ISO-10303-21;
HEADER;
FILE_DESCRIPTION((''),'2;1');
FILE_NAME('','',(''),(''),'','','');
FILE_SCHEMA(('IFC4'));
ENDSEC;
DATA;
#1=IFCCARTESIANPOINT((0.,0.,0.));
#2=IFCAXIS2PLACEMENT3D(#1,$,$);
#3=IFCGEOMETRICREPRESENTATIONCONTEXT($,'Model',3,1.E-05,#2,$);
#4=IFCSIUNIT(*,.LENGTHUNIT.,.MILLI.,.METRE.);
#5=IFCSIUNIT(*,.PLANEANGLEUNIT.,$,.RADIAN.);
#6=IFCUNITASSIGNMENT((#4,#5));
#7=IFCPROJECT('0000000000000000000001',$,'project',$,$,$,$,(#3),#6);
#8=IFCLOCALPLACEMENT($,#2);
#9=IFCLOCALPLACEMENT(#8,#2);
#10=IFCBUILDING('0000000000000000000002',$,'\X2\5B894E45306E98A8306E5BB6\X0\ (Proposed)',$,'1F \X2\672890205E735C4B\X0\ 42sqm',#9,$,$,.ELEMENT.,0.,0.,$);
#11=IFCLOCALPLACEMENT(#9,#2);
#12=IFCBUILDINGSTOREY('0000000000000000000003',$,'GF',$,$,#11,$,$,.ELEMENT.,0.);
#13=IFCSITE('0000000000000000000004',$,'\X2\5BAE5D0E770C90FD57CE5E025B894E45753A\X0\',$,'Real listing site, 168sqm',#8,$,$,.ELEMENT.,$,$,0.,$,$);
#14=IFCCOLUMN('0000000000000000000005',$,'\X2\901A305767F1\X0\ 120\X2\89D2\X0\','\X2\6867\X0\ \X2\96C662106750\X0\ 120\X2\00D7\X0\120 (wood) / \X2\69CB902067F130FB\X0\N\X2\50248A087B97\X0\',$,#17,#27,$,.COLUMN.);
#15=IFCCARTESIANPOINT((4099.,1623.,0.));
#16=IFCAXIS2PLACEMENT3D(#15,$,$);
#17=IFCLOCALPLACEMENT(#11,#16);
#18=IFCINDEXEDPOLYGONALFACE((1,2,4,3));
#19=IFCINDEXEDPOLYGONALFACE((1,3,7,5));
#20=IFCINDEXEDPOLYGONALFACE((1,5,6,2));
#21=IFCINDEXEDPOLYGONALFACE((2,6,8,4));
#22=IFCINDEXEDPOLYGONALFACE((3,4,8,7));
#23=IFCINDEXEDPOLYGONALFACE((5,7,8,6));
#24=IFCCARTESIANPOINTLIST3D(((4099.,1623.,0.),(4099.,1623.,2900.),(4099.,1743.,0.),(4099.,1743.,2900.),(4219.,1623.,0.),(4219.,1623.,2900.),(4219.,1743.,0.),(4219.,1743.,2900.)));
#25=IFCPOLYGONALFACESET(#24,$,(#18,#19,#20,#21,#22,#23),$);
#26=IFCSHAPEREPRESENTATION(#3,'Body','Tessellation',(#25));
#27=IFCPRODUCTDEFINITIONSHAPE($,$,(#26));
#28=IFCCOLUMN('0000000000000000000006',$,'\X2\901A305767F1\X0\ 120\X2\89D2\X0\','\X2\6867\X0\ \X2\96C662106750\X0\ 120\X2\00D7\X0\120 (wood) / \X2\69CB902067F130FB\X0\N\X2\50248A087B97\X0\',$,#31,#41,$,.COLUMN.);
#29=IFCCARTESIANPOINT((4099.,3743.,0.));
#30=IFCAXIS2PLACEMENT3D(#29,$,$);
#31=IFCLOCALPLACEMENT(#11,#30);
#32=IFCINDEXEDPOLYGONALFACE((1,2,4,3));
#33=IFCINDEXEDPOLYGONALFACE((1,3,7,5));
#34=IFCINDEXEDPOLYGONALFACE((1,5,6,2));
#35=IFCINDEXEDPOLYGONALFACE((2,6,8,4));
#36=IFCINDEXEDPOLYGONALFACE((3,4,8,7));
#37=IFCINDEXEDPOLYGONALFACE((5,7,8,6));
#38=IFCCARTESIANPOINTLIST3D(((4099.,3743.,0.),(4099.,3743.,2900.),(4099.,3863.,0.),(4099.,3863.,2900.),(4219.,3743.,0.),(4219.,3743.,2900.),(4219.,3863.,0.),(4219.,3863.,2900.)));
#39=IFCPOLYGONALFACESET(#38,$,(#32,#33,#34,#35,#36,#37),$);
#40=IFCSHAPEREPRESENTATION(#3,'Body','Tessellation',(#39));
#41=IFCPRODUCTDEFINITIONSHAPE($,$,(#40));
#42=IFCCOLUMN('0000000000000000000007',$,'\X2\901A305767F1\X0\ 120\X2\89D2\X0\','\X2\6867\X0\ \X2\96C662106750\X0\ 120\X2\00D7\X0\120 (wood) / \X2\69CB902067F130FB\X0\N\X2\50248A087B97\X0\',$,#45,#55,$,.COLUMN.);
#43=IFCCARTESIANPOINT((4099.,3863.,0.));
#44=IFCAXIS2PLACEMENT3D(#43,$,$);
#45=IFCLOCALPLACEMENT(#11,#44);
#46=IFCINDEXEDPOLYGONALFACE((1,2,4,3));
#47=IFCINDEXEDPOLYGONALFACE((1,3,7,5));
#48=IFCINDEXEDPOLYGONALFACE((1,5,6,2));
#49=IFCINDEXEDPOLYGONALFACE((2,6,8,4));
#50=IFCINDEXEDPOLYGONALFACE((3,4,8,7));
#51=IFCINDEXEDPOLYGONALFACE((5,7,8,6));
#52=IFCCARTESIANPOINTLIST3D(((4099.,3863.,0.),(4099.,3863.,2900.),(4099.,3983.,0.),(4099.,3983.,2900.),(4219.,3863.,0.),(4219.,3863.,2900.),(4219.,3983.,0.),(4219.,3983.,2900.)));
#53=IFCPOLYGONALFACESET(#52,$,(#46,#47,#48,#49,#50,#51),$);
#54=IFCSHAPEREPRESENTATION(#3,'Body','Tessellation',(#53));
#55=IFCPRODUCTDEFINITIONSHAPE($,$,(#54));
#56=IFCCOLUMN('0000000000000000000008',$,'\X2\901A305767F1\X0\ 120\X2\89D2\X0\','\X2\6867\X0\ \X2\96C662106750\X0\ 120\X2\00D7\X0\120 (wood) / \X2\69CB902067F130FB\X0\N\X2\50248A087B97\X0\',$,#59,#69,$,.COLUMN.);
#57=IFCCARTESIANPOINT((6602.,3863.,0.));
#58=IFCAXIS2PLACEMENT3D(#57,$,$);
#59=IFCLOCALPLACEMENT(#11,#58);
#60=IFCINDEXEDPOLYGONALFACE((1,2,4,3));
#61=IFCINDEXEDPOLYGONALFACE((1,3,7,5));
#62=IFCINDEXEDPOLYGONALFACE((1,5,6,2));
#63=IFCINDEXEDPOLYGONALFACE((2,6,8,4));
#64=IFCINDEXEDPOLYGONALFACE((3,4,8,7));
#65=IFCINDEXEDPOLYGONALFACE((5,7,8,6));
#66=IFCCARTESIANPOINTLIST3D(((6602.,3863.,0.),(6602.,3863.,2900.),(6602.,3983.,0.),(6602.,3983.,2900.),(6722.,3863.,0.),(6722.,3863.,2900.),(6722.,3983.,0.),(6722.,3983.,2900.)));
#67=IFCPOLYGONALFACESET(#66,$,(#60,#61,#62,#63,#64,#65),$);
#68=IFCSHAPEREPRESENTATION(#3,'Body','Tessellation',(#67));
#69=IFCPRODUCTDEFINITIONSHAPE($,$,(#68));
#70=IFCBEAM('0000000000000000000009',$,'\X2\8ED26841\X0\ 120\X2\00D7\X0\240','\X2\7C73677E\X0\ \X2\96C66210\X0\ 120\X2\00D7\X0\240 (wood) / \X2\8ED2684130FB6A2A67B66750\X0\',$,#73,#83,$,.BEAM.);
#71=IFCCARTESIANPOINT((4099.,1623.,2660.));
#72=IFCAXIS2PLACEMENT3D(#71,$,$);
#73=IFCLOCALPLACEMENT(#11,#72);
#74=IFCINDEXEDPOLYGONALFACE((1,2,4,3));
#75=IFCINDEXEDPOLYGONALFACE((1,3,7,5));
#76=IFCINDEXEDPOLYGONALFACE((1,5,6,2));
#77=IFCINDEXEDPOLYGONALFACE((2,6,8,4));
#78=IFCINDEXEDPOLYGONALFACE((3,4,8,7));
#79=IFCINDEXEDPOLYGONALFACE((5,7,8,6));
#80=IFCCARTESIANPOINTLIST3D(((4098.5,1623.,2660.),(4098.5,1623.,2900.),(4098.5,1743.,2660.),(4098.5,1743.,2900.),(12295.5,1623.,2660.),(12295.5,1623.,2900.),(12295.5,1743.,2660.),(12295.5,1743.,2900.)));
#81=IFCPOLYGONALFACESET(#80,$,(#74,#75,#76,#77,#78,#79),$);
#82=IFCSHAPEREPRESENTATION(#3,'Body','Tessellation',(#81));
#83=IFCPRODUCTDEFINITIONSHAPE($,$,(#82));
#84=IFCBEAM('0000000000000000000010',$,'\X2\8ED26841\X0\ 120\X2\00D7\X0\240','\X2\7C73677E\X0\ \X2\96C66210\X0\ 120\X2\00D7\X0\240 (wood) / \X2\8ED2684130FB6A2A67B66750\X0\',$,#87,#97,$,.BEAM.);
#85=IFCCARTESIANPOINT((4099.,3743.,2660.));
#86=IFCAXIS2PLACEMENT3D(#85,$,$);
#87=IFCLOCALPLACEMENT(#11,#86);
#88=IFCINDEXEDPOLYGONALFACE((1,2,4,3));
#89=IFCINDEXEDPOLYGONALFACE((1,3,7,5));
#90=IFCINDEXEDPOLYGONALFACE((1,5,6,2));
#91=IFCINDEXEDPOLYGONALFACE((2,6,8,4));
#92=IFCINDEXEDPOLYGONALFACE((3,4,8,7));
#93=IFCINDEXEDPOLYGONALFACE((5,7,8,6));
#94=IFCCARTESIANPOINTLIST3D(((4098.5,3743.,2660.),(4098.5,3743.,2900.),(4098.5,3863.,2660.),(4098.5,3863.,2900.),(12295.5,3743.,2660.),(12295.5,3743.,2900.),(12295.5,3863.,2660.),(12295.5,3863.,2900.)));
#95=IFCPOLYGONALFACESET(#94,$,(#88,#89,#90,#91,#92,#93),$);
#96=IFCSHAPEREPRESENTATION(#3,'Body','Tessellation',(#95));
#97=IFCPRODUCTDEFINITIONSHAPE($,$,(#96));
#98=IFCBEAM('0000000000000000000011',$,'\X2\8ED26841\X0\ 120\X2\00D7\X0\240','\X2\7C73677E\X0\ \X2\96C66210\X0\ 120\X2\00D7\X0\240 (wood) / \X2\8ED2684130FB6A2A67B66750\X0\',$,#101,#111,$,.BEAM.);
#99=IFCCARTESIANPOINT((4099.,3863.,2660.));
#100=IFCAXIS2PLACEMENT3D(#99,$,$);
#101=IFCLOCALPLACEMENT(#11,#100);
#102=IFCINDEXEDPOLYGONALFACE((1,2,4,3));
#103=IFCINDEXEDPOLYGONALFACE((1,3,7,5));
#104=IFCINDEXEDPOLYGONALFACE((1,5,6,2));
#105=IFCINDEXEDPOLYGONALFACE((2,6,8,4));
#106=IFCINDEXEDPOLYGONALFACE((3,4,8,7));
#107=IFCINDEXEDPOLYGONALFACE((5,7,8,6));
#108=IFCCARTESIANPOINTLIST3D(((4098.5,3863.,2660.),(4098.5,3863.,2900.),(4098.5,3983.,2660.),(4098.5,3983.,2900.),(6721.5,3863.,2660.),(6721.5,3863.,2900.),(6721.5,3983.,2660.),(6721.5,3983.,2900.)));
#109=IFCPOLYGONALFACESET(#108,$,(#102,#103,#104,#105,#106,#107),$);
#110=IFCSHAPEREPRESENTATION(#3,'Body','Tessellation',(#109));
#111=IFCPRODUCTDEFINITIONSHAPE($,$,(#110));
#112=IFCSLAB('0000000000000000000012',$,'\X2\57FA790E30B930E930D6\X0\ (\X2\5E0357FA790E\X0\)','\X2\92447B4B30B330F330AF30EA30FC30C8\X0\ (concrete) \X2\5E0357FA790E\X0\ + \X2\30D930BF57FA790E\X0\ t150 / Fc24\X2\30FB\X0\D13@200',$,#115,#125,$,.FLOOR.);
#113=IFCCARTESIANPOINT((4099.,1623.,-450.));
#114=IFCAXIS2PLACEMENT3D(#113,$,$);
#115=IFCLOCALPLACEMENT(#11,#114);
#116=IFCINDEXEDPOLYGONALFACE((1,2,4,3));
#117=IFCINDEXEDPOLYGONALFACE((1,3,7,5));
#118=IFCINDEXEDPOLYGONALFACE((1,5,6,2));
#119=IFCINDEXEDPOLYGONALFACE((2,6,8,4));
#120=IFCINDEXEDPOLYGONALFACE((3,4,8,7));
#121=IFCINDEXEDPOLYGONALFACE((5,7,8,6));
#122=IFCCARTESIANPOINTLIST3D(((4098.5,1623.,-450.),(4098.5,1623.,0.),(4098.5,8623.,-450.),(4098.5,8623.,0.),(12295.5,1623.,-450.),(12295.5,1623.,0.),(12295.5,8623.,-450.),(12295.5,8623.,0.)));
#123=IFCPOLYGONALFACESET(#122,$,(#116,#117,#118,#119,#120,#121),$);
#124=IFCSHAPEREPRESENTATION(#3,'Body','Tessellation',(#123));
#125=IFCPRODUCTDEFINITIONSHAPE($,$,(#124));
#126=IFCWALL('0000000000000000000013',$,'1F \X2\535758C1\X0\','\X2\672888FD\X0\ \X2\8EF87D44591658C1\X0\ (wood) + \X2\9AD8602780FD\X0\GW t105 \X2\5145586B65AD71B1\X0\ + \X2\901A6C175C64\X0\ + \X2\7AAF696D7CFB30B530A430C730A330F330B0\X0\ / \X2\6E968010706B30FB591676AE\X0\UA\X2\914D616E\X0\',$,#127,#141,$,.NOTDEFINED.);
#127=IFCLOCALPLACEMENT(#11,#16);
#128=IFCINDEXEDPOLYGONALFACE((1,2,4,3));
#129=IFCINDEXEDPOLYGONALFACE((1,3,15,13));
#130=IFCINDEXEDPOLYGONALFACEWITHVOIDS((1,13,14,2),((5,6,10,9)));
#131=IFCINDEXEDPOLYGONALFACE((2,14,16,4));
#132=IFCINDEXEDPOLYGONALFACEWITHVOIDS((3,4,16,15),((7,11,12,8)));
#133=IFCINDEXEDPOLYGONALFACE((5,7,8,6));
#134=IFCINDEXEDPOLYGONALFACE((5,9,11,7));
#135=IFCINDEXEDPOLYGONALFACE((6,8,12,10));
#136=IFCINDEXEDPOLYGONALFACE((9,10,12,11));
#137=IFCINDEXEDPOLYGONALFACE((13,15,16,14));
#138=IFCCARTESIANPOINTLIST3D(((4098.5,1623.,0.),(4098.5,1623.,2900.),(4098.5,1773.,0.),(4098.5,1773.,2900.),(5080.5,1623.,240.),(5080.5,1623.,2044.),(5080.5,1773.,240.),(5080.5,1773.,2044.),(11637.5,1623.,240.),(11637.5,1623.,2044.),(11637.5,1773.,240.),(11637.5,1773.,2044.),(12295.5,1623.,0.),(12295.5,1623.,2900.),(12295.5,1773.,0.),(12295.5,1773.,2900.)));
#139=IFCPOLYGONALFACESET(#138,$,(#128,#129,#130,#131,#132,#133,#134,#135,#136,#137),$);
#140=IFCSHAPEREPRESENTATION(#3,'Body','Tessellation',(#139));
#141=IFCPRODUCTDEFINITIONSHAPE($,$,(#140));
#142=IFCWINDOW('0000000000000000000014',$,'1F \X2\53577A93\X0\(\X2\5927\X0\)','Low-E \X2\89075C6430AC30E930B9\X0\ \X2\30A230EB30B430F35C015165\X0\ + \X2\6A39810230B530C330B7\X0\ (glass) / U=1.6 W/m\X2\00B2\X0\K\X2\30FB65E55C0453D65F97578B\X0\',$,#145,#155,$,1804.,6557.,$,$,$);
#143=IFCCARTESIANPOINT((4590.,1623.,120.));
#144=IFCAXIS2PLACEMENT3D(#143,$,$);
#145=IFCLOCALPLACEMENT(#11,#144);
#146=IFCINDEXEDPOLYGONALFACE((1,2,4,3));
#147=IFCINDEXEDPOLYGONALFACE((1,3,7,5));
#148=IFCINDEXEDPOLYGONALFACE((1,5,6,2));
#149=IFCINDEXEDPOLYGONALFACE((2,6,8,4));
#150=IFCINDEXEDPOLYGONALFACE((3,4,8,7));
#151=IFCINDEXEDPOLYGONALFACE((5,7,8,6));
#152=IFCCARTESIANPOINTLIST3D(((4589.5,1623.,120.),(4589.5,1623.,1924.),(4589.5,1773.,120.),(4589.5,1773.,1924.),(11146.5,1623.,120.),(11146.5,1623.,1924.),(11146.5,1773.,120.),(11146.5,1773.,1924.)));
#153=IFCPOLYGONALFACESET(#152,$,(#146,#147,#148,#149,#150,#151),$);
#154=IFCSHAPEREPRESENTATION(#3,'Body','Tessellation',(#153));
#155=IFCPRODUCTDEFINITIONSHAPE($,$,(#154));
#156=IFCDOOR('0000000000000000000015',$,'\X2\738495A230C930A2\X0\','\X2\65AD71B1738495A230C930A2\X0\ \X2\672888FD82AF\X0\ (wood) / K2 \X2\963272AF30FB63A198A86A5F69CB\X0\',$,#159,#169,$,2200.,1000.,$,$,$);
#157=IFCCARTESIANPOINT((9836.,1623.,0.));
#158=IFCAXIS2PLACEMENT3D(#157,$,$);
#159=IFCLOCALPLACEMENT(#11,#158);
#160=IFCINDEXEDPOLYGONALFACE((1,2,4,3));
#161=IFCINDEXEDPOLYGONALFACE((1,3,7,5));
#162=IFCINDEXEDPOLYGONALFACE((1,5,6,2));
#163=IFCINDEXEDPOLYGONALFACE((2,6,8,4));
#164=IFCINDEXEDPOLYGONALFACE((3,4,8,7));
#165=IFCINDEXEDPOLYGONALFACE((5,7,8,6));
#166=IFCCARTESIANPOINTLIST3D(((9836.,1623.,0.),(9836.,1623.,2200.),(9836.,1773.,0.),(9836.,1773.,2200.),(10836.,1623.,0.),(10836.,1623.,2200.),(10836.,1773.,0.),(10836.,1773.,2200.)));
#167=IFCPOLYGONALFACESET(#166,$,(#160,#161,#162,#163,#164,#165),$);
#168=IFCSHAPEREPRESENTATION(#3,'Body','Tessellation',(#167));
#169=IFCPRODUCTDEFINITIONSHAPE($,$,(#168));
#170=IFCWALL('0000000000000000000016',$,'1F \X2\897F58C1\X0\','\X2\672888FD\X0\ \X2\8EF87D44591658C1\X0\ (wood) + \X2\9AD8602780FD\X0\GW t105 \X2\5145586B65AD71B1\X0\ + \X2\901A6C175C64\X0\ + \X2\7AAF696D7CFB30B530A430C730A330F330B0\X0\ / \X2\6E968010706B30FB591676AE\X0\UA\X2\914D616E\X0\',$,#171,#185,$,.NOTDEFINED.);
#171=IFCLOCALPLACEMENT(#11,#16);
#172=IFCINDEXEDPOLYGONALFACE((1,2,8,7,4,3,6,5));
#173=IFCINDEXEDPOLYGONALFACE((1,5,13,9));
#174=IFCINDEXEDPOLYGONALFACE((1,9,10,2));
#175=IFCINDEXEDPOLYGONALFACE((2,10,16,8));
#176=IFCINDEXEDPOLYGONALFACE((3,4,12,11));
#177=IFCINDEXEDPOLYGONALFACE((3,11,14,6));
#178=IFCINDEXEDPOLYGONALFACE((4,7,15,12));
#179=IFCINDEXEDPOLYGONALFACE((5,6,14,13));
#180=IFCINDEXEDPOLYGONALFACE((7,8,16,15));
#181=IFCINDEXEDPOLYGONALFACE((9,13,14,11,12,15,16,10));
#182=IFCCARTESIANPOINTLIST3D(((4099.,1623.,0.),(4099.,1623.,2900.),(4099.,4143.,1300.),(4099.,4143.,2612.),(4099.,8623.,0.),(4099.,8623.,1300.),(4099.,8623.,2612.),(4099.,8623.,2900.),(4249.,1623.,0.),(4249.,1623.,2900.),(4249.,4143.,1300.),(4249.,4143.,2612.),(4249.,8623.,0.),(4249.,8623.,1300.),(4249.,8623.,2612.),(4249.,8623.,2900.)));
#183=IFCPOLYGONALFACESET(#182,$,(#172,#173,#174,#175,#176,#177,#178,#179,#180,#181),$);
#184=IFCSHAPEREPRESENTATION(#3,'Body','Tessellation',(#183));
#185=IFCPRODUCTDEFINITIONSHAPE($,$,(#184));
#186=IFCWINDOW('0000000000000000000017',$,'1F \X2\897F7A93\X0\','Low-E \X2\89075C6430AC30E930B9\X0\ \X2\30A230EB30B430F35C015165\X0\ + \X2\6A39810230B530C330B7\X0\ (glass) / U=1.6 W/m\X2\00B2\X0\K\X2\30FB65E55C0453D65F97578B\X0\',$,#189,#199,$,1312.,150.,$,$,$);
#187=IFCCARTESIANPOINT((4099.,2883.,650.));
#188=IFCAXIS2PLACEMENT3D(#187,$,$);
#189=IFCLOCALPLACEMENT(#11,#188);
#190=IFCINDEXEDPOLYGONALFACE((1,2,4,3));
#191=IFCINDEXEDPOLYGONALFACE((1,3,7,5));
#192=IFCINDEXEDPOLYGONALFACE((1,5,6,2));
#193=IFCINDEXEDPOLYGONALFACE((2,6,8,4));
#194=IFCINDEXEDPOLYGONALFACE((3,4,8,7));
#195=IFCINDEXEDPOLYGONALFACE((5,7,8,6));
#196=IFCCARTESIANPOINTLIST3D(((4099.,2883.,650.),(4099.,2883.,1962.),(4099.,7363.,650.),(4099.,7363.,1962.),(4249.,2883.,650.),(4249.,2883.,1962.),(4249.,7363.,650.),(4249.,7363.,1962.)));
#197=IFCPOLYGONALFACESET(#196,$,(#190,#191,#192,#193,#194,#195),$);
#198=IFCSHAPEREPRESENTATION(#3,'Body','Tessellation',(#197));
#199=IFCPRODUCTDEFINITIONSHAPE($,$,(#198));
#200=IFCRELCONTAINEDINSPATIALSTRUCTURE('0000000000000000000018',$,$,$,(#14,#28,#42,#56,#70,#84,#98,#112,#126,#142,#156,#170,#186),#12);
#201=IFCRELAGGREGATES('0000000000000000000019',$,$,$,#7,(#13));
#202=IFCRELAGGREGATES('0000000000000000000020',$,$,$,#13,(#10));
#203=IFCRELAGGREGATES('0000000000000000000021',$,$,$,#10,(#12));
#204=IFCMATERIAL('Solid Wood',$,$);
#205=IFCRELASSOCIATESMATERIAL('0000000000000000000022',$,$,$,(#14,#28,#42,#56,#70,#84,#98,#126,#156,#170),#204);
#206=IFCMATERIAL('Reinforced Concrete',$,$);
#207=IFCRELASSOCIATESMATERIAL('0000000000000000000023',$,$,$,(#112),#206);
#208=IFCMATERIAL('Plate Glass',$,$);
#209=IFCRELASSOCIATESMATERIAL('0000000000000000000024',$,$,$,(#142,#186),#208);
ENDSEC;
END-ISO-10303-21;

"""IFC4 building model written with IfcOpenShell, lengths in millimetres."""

from ifc_helpers import new_model, si_unit, frame, frame_2d, origin, place, context, project, spatial, rectangle, extrude, material, element, fill, save


model = new_model("IFC4")

# Units and contexts
model_context = context("Model", 3, precision=1e-05, world=origin())
ifc_project = project(units=[si_unit("LENGTHUNIT", "METRE", prefix="MILLI"), si_unit("PLANEANGLEUNIT", "RADIAN")], contexts=[model_context])

# Site, building, storey
site_placement = place(None, origin())
site = spatial("IfcSite", under=ifc_project, at=site_placement, Name="宮崎県都城市安久町", ObjectType="Real listing site, 168sqm", CompositionType="ELEMENT", RefElevation=0.0)
building_placement = place(site_placement, origin())
building = spatial("IfcBuilding", under=site, at=building_placement, Name="安久の風の家 (Proposed)", ObjectType="1F 木造平屋 42sqm", CompositionType="ELEMENT", ElevationOfRefHeight=0.0, ElevationOfTerrain=0.0)
storey_placement = place(building_placement, origin())
storey = spatial("IfcBuildingStorey", under=building, at=storey_placement, Name="GF", CompositionType="ELEMENT", Elevation=0.0)

# Columns
ifc_material_1 = material(Name="Solid Wood")
column_1_placement = place(storey_placement, frame((4099.0, 1623.0, 0.0)))
element("IfcColumn", 1, at=column_1_placement, inside=storey, material=ifc_material_1, Name="通し柱 120角", Description="桧 集成材 120×120 (wood) / 構造柱・N値計算", PredefinedType="COLUMN", context=model_context, shape_type="SweptSolid", body=[
    extrude(rectangle(XDim=120.0, YDim=120.0, at=frame_2d((60.0, 60.0))), frame((4099.0, 1623.0, 0.0)), (0.0, 0.0, 1.0), 2900.0),
])
column_2_placement = place(storey_placement, frame((4099.0, 3743.0, 0.0)))
element("IfcColumn", 2, at=column_2_placement, inside=storey, material=ifc_material_1, Name="通し柱 120角", Description="桧 集成材 120×120 (wood) / 構造柱・N値計算", PredefinedType="COLUMN", context=model_context, shape_type="SweptSolid", body=[
    extrude(rectangle(XDim=120.0, YDim=120.0, at=frame_2d((60.0, 60.0))), frame((4099.0, 3743.0, 0.0)), (0.0, 0.0, 1.0), 2900.0),
])
column_3_placement = place(storey_placement, frame((4099.0, 3863.0, 0.0)))
element("IfcColumn", 3, at=column_3_placement, inside=storey, material=ifc_material_1, Name="通し柱 120角", Description="桧 集成材 120×120 (wood) / 構造柱・N値計算", PredefinedType="COLUMN", context=model_context, shape_type="SweptSolid", body=[
    extrude(rectangle(XDim=120.0, YDim=120.0, at=frame_2d((60.0, 60.0))), frame((4099.0, 3863.0, 0.0)), (0.0, 0.0, 1.0), 2900.0),
])
column_4_placement = place(storey_placement, frame((6602.0, 3863.0, 0.0)))
element("IfcColumn", 4, at=column_4_placement, inside=storey, material=ifc_material_1, Name="通し柱 120角", Description="桧 集成材 120×120 (wood) / 構造柱・N値計算", PredefinedType="COLUMN", context=model_context, shape_type="SweptSolid", body=[
    extrude(rectangle(XDim=120.0, YDim=120.0, at=frame_2d((60.0, 60.0))), frame((6602.0, 3863.0, 0.0)), (0.0, 0.0, 1.0), 2900.0),
])

# Beams
beam_1_placement = place(storey_placement, frame((4099.0, 1623.0, 2660.0)))
element("IfcBeam", 5, at=beam_1_placement, inside=storey, material=ifc_material_1, Name="軒桁 120×240", Description="米松 集成 120×240 (wood) / 軒桁・横架材", PredefinedType="BEAM", context=model_context, shape_type="SweptSolid", body=[
    extrude(rectangle(XDim=8197.0, YDim=120.0, at=frame_2d((4098.0, 60.0))), frame((4099.0, 1623.0, 2660.0)), (0.0, 0.0, 1.0), 240.0),
])
beam_2_placement = place(storey_placement, frame((4099.0, 3743.0, 2660.0)))
element("IfcBeam", 6, at=beam_2_placement, inside=storey, material=ifc_material_1, Name="軒桁 120×240", Description="米松 集成 120×240 (wood) / 軒桁・横架材", PredefinedType="BEAM", context=model_context, shape_type="SweptSolid", body=[
    extrude(rectangle(XDim=8197.0, YDim=120.0, at=frame_2d((4098.0, 60.0))), frame((4099.0, 3743.0, 2660.0)), (0.0, 0.0, 1.0), 240.0),
])
beam_3_placement = place(storey_placement, frame((4099.0, 3863.0, 2660.0)))
element("IfcBeam", 7, at=beam_3_placement, inside=storey, material=ifc_material_1, Name="軒桁 120×240", Description="米松 集成 120×240 (wood) / 軒桁・横架材", PredefinedType="BEAM", context=model_context, shape_type="SweptSolid", body=[
    extrude(rectangle(XDim=2623.0, YDim=120.0, at=frame_2d((1311.0, 60.0))), frame((4099.0, 3863.0, 2660.0)), (0.0, 0.0, 1.0), 240.0),
])

# Slab
ifc_material_2 = material(Name="Reinforced Concrete")
slab_1_placement = place(storey_placement, frame((4099.0, 1623.0, -450.0)))
element("IfcSlab", 8, at=slab_1_placement, inside=storey, material=ifc_material_2, Name="基礎スラブ (布基礎)", Description="鉄筋コンクリート (concrete) 布基礎 + ベタ基礎 t150 / Fc24・D13@200", PredefinedType="FLOOR", context=model_context, shape_type="SweptSolid", body=[
    extrude(rectangle(XDim=8197.0, YDim=7000.0, at=frame_2d((4098.0, 3500.0))), frame((4099.0, 1623.0, -450.0)), (0.0, 0.0, 1.0), 450.0),
])

# Wall, openings, window, door
wall_1_placement = place(storey_placement, frame((4099.0, 1623.0, 0.0)))
wall_1 = element("IfcWall", 9, at=wall_1_placement, inside=storey, material=ifc_material_1, Name="1F 南壁", Description="木製 軸組外壁 (wood) + 高性能GW t105 充填断熱 + 通気層 + 窯業系サイディング / 準耐火・外皮UA配慮", PredefinedType="NOTDEFINED", context=model_context, shape_type="SweptSolid", body=[
    extrude(rectangle(XDim=8197.0, YDim=150.0, at=frame_2d((4098.0, 75.0))), frame((4099.0, 1623.0, 0.0)), (0.0, 0.0, 1.0), 2900.0),
])
opening_1_placement = place(storey_placement, frame((4590.0, 1623.0, 120.0)))
opening_1 = element("IfcOpeningElement", 10, at=opening_1_placement, cuts=wall_1, PredefinedType="NOTDEFINED", context=model_context, shape_type="SweptSolid", body=[
    extrude(rectangle(XDim=6557.0, YDim=150.0, at=frame_2d((3278.0, 75.0))), frame((4590.0, 1623.0, 120.0)), (0.0, 0.0, 1.0), 1804.0),
])
opening_2_placement = place(storey_placement, frame((9836.0, 1623.0, 0.0)))
opening_2 = element("IfcOpeningElement", 11, at=opening_2_placement, cuts=wall_1, PredefinedType="NOTDEFINED", context=model_context, shape_type="SweptSolid", body=[
    extrude(rectangle(XDim=1000.0, YDim=150.0, at=frame_2d((500.0, 75.0))), frame((9836.0, 1623.0, 0.0)), (0.0, 0.0, 1.0), 2200.0),
])
ifc_material_3 = material(Name="Plate Glass")
window_1_placement = place(storey_placement, frame((4590.0, 1623.0, 120.0)))
window_1 = element("IfcWindow", 12, at=window_1_placement, inside=storey, material=ifc_material_3, Name="1F 南窓(大)", Description="Low-E 複層ガラス アルゴン封入 + 樹脂サッシ (glass) / U=1.6 W/m²K・日射取得型", OverallHeight=1804.0, OverallWidth=6557.0, context=model_context, shape_type="SweptSolid", body=[
    extrude(rectangle(XDim=6557.0, YDim=150.0, at=frame_2d((3278.0, 75.0))), frame((4590.0, 1623.0, 120.0)), (0.0, 0.0, 1.0), 1804.0),
])
fill(opening_1, window_1)
door_placement = place(storey_placement, frame((9836.0, 1623.0, 0.0)))
door = element("IfcDoor", 13, at=door_placement, inside=storey, material=ifc_material_1, Name="玄関ドア", Description="断熱玄関ドア 木製芯 (wood) / K2 防犯・採風機構", OverallHeight=2200.0, OverallWidth=1000.0, context=model_context, shape_type="SweptSolid", body=[
    extrude(rectangle(XDim=1000.0, YDim=150.0, at=frame_2d((500.0, 75.0))), frame((9836.0, 1623.0, 0.0)), (0.0, 0.0, 1.0), 2200.0),
])
fill(opening_2, door)

# Wall, opening, window
wall_2_placement = place(storey_placement, frame((4099.0, 1623.0, 0.0)))
wall_2 = element("IfcWall", 14, at=wall_2_placement, inside=storey, material=ifc_material_1, Name="1F 西壁", Description="木製 軸組外壁 (wood) + 高性能GW t105 充填断熱 + 通気層 + 窯業系サイディング / 準耐火・外皮UA配慮", PredefinedType="NOTDEFINED", context=model_context, shape_type="SweptSolid", body=[
    extrude(rectangle(XDim=150.0, YDim=7000.0, at=frame_2d((75.0, 3500.0))), frame((4099.0, 1623.0, 0.0)), (0.0, 0.0, 1.0), 2900.0),
])
opening_3_placement = place(storey_placement, frame((4099.0, 2883.0, 650.0)))
opening_3 = element("IfcOpeningElement", 15, at=opening_3_placement, cuts=wall_2, PredefinedType="NOTDEFINED", context=model_context, shape_type="SweptSolid", body=[
    extrude(rectangle(XDim=150.0, YDim=4480.0, at=frame_2d((75.0, 2240.0))), frame((4099.0, 2883.0, 650.0)), (0.0, 0.0, 1.0), 1312.0),
])
window_2_placement = place(storey_placement, frame((4099.0, 2883.0, 650.0)))
window_2 = element("IfcWindow", 16, at=window_2_placement, inside=storey, material=ifc_material_3, Name="1F 西窓", Description="Low-E 複層ガラス アルゴン封入 + 樹脂サッシ (glass) / U=1.6 W/m²K・日射取得型", OverallHeight=1312.0, OverallWidth=150.0, context=model_context, shape_type="SweptSolid", body=[
    extrude(rectangle(XDim=150.0, YDim=4480.0, at=frame_2d((75.0, 2240.0))), frame((4099.0, 2883.0, 650.0)), (0.0, 0.0, 1.0), 1312.0),
])
fill(opening_3, window_2)

save(model, "model.ifc")
